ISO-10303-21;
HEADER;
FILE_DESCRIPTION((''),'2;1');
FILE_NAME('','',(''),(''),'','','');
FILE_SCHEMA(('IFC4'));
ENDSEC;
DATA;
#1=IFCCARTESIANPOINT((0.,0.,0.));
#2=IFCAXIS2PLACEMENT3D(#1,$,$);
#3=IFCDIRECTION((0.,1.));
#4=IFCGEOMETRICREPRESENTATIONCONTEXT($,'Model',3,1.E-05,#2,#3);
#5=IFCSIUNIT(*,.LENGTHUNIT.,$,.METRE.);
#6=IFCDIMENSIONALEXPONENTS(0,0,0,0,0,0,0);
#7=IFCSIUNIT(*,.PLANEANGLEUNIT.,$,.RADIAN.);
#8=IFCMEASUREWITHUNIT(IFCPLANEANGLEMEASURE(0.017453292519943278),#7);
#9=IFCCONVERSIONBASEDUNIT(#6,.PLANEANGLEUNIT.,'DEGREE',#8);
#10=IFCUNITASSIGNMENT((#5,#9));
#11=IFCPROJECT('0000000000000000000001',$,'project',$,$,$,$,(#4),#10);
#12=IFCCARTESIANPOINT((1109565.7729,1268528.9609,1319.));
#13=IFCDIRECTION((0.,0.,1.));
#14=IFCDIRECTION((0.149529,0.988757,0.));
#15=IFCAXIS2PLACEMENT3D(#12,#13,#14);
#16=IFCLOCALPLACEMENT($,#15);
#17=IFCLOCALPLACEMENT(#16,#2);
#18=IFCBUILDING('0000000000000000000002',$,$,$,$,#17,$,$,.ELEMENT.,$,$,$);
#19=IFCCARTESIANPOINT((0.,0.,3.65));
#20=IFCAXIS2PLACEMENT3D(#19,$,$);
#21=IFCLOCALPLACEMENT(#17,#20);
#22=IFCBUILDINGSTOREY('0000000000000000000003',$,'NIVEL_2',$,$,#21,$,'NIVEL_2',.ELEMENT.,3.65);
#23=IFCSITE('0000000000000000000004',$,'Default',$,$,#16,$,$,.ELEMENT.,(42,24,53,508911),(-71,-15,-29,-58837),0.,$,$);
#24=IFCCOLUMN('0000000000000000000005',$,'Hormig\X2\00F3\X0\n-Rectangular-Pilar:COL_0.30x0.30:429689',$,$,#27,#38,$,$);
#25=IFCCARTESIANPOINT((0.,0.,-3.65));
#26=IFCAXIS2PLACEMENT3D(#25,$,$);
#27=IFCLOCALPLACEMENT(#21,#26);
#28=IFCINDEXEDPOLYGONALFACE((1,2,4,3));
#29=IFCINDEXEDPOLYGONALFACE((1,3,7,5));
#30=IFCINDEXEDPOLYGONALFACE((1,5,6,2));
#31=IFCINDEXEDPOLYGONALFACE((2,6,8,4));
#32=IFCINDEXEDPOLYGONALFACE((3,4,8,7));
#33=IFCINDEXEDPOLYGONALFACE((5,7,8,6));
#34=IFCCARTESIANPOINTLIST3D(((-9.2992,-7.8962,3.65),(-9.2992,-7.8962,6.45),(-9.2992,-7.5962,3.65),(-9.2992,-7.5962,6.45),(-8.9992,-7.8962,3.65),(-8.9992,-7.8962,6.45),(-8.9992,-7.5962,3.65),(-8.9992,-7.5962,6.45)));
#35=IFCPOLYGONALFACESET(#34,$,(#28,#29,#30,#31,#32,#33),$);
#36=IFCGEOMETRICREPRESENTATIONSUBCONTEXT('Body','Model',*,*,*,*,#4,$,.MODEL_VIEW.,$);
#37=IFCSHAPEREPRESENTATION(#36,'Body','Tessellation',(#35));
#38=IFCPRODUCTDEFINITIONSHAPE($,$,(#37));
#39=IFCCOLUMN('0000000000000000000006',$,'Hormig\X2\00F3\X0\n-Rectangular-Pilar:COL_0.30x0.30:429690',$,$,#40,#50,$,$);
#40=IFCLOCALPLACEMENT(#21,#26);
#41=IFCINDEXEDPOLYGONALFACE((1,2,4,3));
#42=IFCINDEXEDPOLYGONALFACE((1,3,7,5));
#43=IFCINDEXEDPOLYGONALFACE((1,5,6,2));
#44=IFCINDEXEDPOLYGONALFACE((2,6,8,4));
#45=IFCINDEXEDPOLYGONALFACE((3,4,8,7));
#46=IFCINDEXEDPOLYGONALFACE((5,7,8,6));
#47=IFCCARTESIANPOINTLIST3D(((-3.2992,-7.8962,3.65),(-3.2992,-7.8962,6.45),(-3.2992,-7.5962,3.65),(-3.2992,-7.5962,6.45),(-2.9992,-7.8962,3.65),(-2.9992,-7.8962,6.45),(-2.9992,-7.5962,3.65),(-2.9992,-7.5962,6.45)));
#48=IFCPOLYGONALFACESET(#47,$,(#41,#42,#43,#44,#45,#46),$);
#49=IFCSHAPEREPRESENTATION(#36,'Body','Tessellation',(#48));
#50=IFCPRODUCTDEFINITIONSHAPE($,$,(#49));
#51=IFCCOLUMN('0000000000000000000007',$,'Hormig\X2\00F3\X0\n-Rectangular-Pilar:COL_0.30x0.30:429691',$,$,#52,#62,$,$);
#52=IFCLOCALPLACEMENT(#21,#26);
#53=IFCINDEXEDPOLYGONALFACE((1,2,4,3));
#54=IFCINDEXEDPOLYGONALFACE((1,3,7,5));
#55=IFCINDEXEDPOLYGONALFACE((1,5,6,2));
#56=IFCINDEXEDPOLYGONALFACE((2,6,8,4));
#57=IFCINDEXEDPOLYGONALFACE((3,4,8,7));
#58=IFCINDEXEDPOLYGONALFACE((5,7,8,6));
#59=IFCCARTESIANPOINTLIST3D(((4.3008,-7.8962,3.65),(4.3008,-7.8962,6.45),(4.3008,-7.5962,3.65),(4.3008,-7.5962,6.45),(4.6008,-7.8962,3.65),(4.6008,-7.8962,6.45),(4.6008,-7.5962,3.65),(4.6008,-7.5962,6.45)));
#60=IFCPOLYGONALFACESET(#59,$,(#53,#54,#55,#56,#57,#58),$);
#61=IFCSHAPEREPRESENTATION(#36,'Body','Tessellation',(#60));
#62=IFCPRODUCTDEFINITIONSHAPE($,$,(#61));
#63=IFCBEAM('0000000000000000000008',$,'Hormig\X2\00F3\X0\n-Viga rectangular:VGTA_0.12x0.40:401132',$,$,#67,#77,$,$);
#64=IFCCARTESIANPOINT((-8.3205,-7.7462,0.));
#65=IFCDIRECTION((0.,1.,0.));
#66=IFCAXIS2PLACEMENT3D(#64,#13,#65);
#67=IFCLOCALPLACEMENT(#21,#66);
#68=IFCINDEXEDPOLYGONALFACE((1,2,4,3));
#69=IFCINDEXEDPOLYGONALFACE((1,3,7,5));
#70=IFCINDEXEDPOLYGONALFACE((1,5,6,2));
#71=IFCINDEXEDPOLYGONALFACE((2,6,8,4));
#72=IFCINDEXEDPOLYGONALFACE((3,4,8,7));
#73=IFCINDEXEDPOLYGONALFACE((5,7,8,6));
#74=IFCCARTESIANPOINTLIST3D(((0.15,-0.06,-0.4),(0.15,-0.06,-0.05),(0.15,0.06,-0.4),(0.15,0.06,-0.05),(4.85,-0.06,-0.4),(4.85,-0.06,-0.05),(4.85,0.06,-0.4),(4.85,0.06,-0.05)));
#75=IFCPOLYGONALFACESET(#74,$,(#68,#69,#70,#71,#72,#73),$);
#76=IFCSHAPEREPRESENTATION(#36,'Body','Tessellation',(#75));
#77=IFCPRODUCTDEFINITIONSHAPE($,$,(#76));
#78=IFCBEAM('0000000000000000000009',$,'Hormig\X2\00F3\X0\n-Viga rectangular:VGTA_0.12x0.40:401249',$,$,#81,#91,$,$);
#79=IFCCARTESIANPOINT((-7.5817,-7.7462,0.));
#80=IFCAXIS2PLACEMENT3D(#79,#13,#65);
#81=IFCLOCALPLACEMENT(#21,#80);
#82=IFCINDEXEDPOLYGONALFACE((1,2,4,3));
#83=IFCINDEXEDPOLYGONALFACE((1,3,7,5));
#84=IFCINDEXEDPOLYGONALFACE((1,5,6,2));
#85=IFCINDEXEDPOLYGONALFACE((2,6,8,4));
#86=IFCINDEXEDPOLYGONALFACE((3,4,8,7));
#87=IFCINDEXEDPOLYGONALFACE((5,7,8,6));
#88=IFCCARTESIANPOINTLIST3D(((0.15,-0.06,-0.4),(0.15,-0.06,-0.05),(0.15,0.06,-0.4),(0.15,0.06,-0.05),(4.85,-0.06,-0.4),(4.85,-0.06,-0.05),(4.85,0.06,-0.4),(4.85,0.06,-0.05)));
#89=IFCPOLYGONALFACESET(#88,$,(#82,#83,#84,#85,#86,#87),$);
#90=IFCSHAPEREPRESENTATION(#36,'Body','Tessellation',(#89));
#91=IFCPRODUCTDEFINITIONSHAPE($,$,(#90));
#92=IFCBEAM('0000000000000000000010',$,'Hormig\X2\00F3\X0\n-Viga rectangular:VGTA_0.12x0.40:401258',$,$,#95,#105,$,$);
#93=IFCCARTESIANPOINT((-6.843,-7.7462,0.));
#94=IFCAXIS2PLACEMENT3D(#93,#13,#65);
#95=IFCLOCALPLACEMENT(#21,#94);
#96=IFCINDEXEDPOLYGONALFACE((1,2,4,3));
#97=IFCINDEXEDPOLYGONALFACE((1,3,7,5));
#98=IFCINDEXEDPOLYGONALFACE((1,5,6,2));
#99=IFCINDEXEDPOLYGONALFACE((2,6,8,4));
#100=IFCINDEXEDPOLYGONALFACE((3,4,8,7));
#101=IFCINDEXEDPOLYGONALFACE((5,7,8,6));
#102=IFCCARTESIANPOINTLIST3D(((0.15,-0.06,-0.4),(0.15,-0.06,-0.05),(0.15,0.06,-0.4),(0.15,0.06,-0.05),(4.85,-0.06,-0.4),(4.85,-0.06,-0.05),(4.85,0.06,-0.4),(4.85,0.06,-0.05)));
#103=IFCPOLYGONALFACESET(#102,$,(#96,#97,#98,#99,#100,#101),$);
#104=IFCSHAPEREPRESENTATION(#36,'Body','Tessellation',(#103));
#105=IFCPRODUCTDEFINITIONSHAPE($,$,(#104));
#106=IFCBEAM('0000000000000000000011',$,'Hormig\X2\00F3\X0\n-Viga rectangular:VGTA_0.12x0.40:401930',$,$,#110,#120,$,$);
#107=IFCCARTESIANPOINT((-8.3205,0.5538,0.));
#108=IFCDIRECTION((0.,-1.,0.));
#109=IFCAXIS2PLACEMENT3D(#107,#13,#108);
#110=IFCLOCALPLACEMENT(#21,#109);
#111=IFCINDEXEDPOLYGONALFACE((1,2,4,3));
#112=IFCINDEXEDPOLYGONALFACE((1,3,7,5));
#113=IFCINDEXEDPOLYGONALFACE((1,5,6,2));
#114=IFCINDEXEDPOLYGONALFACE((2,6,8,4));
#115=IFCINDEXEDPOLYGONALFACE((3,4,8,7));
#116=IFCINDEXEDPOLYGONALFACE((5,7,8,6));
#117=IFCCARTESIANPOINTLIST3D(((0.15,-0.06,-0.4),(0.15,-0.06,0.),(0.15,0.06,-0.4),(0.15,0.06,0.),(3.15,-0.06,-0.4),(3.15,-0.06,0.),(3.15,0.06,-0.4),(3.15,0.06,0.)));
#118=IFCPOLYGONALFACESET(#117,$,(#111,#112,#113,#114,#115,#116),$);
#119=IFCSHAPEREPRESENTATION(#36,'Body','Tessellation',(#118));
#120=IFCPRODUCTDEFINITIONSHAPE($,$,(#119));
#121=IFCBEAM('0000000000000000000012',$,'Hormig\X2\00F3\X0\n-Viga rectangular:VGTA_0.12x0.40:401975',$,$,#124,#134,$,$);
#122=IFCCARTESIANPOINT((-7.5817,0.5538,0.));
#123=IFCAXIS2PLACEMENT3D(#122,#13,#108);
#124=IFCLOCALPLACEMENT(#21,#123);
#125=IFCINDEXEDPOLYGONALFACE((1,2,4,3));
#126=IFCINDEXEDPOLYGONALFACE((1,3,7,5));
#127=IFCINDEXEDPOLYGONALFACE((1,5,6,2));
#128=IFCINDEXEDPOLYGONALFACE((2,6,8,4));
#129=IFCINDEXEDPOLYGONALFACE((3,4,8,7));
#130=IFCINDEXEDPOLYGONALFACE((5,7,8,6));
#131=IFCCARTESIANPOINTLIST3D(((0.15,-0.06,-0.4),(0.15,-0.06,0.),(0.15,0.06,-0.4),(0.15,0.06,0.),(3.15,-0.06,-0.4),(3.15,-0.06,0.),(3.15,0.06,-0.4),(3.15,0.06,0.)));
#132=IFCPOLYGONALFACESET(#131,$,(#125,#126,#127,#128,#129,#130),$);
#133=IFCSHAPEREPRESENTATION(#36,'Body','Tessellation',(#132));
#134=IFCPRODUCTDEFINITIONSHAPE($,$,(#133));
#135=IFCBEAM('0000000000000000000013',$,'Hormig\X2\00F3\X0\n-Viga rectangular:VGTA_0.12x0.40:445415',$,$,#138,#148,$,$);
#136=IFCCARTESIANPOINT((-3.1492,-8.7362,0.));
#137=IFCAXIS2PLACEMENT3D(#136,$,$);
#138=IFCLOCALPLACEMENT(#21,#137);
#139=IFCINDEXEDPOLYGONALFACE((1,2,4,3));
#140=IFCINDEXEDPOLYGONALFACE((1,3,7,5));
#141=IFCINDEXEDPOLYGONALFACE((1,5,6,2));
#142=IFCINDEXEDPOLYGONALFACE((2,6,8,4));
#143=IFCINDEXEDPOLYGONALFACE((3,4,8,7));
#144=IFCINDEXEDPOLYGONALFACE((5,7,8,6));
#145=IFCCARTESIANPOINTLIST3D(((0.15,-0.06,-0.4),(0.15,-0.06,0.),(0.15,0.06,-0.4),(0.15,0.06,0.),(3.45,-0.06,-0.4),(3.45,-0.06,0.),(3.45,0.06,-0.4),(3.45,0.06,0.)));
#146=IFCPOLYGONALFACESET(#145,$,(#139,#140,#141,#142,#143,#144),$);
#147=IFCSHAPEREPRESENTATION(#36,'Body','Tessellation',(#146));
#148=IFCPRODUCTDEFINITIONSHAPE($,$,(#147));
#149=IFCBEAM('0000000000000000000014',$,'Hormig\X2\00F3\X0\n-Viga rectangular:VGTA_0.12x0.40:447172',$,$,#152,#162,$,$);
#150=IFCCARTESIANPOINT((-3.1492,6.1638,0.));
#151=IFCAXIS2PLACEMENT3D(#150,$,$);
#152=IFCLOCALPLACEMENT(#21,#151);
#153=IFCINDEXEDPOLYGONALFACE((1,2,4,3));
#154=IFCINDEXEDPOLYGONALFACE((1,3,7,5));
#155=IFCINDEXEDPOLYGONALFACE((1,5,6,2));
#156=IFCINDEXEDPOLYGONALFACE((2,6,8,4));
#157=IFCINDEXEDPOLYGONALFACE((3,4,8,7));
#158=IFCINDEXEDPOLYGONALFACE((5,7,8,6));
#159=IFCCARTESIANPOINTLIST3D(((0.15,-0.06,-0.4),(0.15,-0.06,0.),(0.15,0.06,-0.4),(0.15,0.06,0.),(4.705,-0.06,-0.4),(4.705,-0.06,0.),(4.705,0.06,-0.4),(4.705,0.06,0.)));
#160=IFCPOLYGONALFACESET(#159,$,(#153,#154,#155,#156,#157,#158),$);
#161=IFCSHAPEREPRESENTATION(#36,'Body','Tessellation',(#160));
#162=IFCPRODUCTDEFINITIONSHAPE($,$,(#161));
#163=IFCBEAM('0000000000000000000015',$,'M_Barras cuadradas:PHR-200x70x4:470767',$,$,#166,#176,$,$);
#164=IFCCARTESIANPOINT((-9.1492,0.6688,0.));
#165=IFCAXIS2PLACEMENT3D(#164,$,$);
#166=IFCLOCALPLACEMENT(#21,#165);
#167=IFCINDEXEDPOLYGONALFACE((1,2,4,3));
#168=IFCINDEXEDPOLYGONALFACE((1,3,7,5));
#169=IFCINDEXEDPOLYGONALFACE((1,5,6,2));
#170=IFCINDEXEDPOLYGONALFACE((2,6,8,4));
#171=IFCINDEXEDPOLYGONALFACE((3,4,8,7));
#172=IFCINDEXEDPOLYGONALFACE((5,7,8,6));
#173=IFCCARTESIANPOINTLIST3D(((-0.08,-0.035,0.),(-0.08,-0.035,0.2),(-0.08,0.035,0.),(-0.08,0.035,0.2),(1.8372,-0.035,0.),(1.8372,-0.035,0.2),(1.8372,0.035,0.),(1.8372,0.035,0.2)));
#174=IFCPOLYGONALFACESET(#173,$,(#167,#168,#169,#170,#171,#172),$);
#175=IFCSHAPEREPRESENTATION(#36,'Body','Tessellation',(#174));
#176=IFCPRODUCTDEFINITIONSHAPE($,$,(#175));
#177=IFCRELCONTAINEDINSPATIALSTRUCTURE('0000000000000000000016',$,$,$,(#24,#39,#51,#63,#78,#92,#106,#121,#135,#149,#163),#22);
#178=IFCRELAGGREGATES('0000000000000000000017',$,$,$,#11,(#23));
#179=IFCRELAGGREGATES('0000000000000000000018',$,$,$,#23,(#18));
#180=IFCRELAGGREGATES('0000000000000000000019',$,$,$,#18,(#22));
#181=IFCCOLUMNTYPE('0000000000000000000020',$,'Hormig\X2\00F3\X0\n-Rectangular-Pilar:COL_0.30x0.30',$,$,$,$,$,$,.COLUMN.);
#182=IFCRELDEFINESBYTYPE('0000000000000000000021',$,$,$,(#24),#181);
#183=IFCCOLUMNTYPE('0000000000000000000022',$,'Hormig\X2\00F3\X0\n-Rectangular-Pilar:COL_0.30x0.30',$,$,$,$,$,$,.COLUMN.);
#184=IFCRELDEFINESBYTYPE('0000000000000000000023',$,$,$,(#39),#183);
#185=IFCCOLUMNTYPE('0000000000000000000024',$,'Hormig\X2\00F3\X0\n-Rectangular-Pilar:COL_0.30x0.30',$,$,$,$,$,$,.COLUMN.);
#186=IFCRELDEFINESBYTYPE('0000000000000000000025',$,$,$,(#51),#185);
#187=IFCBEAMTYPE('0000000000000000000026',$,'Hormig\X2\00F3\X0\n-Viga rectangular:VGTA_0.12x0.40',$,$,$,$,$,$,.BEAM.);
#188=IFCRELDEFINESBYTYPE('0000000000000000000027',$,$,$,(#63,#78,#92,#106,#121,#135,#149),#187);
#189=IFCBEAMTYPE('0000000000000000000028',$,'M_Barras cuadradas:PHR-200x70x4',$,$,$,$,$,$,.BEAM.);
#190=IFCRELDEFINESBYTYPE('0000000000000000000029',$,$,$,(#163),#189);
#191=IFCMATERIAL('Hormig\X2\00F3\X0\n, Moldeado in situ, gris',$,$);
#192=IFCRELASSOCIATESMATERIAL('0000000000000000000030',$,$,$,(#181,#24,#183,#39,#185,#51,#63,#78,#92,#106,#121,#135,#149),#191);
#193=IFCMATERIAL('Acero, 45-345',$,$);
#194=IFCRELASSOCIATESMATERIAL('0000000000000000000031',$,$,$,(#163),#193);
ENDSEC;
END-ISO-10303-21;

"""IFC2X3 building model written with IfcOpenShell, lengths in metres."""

from ifc_helpers import new_model, entity, si_unit, converted_unit, direction, frame, frame_2d, origin, origin_2d_with_axis, place, context, subcontext, project, spatial, rectangle, extrude, source, transform, mapped, material, type_object, type_shapes, element, save


model = new_model("IFC2X3")

# Units and contexts
model_context = context("Model", 3, precision=1e-05, world=origin(), true_north=direction((0.0, 1.0)))
body_context = subcontext(model_context, "Body", "Model", "MODEL_VIEW")
ifc_project = project(units=[si_unit("LENGTHUNIT", "METRE"), converted_unit("PLANEANGLEUNIT", "DEGREE", entity("IfcPlaneAngleMeasure", 0.017453292519943278), si_unit("PLANEANGLEUNIT", "RADIAN"), dimensions=[0, 0, 0, 0, 0, 0, 0])], contexts=[model_context])

# Site, building, storey
site_placement = place(None, frame((1109565.7729, 1268528.9609, 1319.0), z_axis=(0.0, 0.0, 1.0), x_axis=(0.149529, 0.988757, 0.0)))
site = spatial("IfcSite", under=ifc_project, at=site_placement, Name="Default", CompositionType="ELEMENT", RefLatitude=(42, 24, 53, 508911), RefLongitude=(-71, -15, -29, -58837), RefElevation=0.0)
building_placement = place(site_placement, origin())
building = spatial("IfcBuilding", under=site, at=building_placement, CompositionType="ELEMENT")
storey_placement = place(building_placement, frame((0.0, 0.0, 3.65)))
storey = spatial("IfcBuildingStorey", under=building, at=storey_placement, Name="NIVEL_2", LongName="NIVEL_2", CompositionType="ELEMENT", Elevation=3.65)

# Columns
ifc_material_1 = material(Name="Hormigón, Moldeado in situ, gris")
column_type_1 = type_object("IfcColumnType", Name="Hormigón-Rectangular-Pilar:COL_0.30x0.30", PredefinedType="COLUMN", material=ifc_material_1)
shared_shape_1 = source(origin(), body_context, "Body", "SweptSolid", [
    extrude(rectangle(XDim=0.3, YDim=0.3, at=frame_2d((0.0, 0.0), x_axis=(1.0, 0.0))), frame((-9.1492, -7.7462, 3.65)), (0.0, 0.0, 1.0), 2.8),
])
type_shapes(column_type_1, [shared_shape_1])
column_1_placement = place(storey_placement, frame((0.0, 0.0, -3.65)))
element("IfcColumn", 1, at=column_1_placement, inside=storey, type_object=column_type_1, material=ifc_material_1, Name="Hormigón-Rectangular-Pilar:COL_0.30x0.30:429689", context=body_context, shape_type="MappedRepresentation", body=[
    mapped(shared_shape_1, transform((0.0, 0.0, 0.0), scale=1.0)),
])
column_type_2 = type_object("IfcColumnType", Name="Hormigón-Rectangular-Pilar:COL_0.30x0.30", PredefinedType="COLUMN", material=ifc_material_1)
shared_shape_2 = source(origin(), body_context, "Body", "SweptSolid", [
    extrude(rectangle(XDim=0.3, YDim=0.3, at=origin_2d_with_axis()), frame((-3.1492, -7.7462, 3.65)), (0.0, 0.0, 1.0), 2.8),
])
type_shapes(column_type_2, [shared_shape_2])
column_2_placement = place(storey_placement, frame((0.0, 0.0, -3.65)))
element("IfcColumn", 2, at=column_2_placement, inside=storey, type_object=column_type_2, material=ifc_material_1, Name="Hormigón-Rectangular-Pilar:COL_0.30x0.30:429690", context=body_context, shape_type="MappedRepresentation", body=[
    mapped(shared_shape_2, transform((0.0, 0.0, 0.0), scale=1.0)),
])
column_type_3 = type_object("IfcColumnType", Name="Hormigón-Rectangular-Pilar:COL_0.30x0.30", PredefinedType="COLUMN", material=ifc_material_1)
shared_shape_3 = source(origin(), body_context, "Body", "SweptSolid", [
    extrude(rectangle(XDim=0.3, YDim=0.3, at=origin_2d_with_axis()), frame((4.4508, -7.7462, 3.65)), (0.0, 0.0, 1.0), 2.8),
])
type_shapes(column_type_3, [shared_shape_3])
column_3_placement = place(storey_placement, frame((0.0, 0.0, -3.65)))
element("IfcColumn", 3, at=column_3_placement, inside=storey, type_object=column_type_3, material=ifc_material_1, Name="Hormigón-Rectangular-Pilar:COL_0.30x0.30:429691", context=body_context, shape_type="MappedRepresentation", body=[
    mapped(shared_shape_3, transform((0.0, 0.0, 0.0), scale=1.0)),
])

# Beams
beam_type_1 = type_object("IfcBeamType", Name="Hormigón-Viga rectangular:VGTA_0.12x0.40", PredefinedType="BEAM")
beam_1_placement = place(storey_placement, frame((-8.3205, -7.7462, 0.0), z_axis=(0.0, 0.0, 1.0), x_axis=(0.0, 1.0, 0.0)))
element("IfcBeam", 4, at=beam_1_placement, inside=storey, type_object=beam_type_1, material=ifc_material_1, Name="Hormigón-Viga rectangular:VGTA_0.12x0.40:401132", context=body_context, shape_type="SweptSolid", body=[
    extrude(rectangle(XDim=0.35, YDim=0.12, at=frame_2d((0.0, 0.0), x_axis=(1.0, 0.0))), frame((0.15, 0.0, -0.225), z_axis=(1.0, 0.0, 0.0), x_axis=(0.0, 0.0, -1.0)), (0.0, 0.0, 1.0), 4.7),
])
beam_2_placement = place(storey_placement, frame((-7.5817, -7.7462, 0.0), z_axis=(0.0, 0.0, 1.0), x_axis=(0.0, 1.0, 0.0)))
element("IfcBeam", 5, at=beam_2_placement, inside=storey, type_object=beam_type_1, material=ifc_material_1, Name="Hormigón-Viga rectangular:VGTA_0.12x0.40:401249", context=body_context, shape_type="SweptSolid", body=[
    extrude(rectangle(XDim=0.35, YDim=0.12, at=frame_2d((0.0, 0.0), x_axis=(1.0, 0.0))), frame((0.15, 0.0, -0.225), z_axis=(1.0, 0.0, 0.0), x_axis=(0.0, 0.0, -1.0)), (0.0, 0.0, 1.0), 4.7),
])
beam_3_placement = place(storey_placement, frame((-6.843, -7.7462, 0.0), z_axis=(0.0, 0.0, 1.0), x_axis=(0.0, 1.0, 0.0)))
element("IfcBeam", 6, at=beam_3_placement, inside=storey, type_object=beam_type_1, material=ifc_material_1, Name="Hormigón-Viga rectangular:VGTA_0.12x0.40:401258", context=body_context, shape_type="SweptSolid", body=[
    extrude(rectangle(XDim=0.35, YDim=0.12, at=frame_2d((0.0, 0.0), x_axis=(1.0, 0.0))), frame((0.15, 0.0, -0.225), z_axis=(1.0, 0.0, 0.0), x_axis=(0.0, 0.0, -1.0)), (0.0, 0.0, 1.0), 4.7),
])
beam_4_placement = place(storey_placement, frame((-8.3205, 0.5538, 0.0), z_axis=(0.0, 0.0, 1.0), x_axis=(0.0, -1.0, 0.0)))
element("IfcBeam", 7, at=beam_4_placement, inside=storey, type_object=beam_type_1, material=ifc_material_1, Name="Hormigón-Viga rectangular:VGTA_0.12x0.40:401930", context=body_context, shape_type="SweptSolid", body=[
    extrude(rectangle(XDim=0.4, YDim=0.12, at=origin_2d_with_axis()), frame((0.15, 0.0, -0.2), z_axis=(1.0, 0.0, 0.0), x_axis=(0.0, 0.0, -1.0)), (0.0, 0.0, 1.0), 3.0),
])
beam_5_placement = place(storey_placement, frame((-7.5817, 0.5538, 0.0), z_axis=(0.0, 0.0, 1.0), x_axis=(0.0, -1.0, 0.0)))
element("IfcBeam", 8, at=beam_5_placement, inside=storey, type_object=beam_type_1, material=ifc_material_1, Name="Hormigón-Viga rectangular:VGTA_0.12x0.40:401975", context=body_context, shape_type="SweptSolid", body=[
    extrude(rectangle(XDim=0.4, YDim=0.12, at=frame_2d((0.0, 0.0), x_axis=(1.0, 0.0))), frame((0.15, 0.0, -0.2), z_axis=(1.0, 0.0, 0.0), x_axis=(0.0, 0.0, -1.0)), (0.0, 0.0, 1.0), 3.0),
])
beam_6_placement = place(storey_placement, frame((-3.1492, -8.7362, 0.0)))
element("IfcBeam", 9, at=beam_6_placement, inside=storey, type_object=beam_type_1, material=ifc_material_1, Name="Hormigón-Viga rectangular:VGTA_0.12x0.40:445415", context=body_context, shape_type="SweptSolid", body=[
    extrude(rectangle(XDim=0.4, YDim=0.12, at=frame_2d((0.0, 0.0), x_axis=(1.0, 0.0))), frame((0.15, 0.0, -0.2), z_axis=(1.0, 0.0, 0.0), x_axis=(0.0, 0.0, -1.0)), (0.0, 0.0, 1.0), 3.3),
])
beam_7_placement = place(storey_placement, frame((-3.1492, 6.1638, 0.0)))
element("IfcBeam", 10, at=beam_7_placement, inside=storey, type_object=beam_type_1, material=ifc_material_1, Name="Hormigón-Viga rectangular:VGTA_0.12x0.40:447172", context=body_context, shape_type="SweptSolid", body=[
    extrude(rectangle(XDim=0.4, YDim=0.12, at=origin_2d_with_axis()), frame((0.15, 0.0, -0.2), z_axis=(1.0, 0.0, 0.0), x_axis=(0.0, 0.0, -1.0)), (0.0, 0.0, 1.0), 4.555),
])
ifc_material_2 = material(Name="Acero, 45-345")
beam_type_2 = type_object("IfcBeamType", Name="M_Barras cuadradas:PHR-200x70x4", PredefinedType="BEAM")
beam_8_placement = place(storey_placement, frame((-9.1492, 0.6688, 0.0)))
element("IfcBeam", 11, at=beam_8_placement, inside=storey, type_object=beam_type_2, material=ifc_material_2, Name="M_Barras cuadradas:PHR-200x70x4:470767", context=body_context, shape_type="SweptSolid", body=[
    extrude(rectangle(XDim=0.2, YDim=0.07, at=frame_2d((0.0, 0.0), x_axis=(1.0, 0.0))), frame((-0.08, 0.0, 0.1), z_axis=(1.0, 0.0, 0.0), x_axis=(0.0, 0.0, -1.0)), (0.0, 0.0, 1.0), 1.9172),
])

save(model, "model.ifc")
